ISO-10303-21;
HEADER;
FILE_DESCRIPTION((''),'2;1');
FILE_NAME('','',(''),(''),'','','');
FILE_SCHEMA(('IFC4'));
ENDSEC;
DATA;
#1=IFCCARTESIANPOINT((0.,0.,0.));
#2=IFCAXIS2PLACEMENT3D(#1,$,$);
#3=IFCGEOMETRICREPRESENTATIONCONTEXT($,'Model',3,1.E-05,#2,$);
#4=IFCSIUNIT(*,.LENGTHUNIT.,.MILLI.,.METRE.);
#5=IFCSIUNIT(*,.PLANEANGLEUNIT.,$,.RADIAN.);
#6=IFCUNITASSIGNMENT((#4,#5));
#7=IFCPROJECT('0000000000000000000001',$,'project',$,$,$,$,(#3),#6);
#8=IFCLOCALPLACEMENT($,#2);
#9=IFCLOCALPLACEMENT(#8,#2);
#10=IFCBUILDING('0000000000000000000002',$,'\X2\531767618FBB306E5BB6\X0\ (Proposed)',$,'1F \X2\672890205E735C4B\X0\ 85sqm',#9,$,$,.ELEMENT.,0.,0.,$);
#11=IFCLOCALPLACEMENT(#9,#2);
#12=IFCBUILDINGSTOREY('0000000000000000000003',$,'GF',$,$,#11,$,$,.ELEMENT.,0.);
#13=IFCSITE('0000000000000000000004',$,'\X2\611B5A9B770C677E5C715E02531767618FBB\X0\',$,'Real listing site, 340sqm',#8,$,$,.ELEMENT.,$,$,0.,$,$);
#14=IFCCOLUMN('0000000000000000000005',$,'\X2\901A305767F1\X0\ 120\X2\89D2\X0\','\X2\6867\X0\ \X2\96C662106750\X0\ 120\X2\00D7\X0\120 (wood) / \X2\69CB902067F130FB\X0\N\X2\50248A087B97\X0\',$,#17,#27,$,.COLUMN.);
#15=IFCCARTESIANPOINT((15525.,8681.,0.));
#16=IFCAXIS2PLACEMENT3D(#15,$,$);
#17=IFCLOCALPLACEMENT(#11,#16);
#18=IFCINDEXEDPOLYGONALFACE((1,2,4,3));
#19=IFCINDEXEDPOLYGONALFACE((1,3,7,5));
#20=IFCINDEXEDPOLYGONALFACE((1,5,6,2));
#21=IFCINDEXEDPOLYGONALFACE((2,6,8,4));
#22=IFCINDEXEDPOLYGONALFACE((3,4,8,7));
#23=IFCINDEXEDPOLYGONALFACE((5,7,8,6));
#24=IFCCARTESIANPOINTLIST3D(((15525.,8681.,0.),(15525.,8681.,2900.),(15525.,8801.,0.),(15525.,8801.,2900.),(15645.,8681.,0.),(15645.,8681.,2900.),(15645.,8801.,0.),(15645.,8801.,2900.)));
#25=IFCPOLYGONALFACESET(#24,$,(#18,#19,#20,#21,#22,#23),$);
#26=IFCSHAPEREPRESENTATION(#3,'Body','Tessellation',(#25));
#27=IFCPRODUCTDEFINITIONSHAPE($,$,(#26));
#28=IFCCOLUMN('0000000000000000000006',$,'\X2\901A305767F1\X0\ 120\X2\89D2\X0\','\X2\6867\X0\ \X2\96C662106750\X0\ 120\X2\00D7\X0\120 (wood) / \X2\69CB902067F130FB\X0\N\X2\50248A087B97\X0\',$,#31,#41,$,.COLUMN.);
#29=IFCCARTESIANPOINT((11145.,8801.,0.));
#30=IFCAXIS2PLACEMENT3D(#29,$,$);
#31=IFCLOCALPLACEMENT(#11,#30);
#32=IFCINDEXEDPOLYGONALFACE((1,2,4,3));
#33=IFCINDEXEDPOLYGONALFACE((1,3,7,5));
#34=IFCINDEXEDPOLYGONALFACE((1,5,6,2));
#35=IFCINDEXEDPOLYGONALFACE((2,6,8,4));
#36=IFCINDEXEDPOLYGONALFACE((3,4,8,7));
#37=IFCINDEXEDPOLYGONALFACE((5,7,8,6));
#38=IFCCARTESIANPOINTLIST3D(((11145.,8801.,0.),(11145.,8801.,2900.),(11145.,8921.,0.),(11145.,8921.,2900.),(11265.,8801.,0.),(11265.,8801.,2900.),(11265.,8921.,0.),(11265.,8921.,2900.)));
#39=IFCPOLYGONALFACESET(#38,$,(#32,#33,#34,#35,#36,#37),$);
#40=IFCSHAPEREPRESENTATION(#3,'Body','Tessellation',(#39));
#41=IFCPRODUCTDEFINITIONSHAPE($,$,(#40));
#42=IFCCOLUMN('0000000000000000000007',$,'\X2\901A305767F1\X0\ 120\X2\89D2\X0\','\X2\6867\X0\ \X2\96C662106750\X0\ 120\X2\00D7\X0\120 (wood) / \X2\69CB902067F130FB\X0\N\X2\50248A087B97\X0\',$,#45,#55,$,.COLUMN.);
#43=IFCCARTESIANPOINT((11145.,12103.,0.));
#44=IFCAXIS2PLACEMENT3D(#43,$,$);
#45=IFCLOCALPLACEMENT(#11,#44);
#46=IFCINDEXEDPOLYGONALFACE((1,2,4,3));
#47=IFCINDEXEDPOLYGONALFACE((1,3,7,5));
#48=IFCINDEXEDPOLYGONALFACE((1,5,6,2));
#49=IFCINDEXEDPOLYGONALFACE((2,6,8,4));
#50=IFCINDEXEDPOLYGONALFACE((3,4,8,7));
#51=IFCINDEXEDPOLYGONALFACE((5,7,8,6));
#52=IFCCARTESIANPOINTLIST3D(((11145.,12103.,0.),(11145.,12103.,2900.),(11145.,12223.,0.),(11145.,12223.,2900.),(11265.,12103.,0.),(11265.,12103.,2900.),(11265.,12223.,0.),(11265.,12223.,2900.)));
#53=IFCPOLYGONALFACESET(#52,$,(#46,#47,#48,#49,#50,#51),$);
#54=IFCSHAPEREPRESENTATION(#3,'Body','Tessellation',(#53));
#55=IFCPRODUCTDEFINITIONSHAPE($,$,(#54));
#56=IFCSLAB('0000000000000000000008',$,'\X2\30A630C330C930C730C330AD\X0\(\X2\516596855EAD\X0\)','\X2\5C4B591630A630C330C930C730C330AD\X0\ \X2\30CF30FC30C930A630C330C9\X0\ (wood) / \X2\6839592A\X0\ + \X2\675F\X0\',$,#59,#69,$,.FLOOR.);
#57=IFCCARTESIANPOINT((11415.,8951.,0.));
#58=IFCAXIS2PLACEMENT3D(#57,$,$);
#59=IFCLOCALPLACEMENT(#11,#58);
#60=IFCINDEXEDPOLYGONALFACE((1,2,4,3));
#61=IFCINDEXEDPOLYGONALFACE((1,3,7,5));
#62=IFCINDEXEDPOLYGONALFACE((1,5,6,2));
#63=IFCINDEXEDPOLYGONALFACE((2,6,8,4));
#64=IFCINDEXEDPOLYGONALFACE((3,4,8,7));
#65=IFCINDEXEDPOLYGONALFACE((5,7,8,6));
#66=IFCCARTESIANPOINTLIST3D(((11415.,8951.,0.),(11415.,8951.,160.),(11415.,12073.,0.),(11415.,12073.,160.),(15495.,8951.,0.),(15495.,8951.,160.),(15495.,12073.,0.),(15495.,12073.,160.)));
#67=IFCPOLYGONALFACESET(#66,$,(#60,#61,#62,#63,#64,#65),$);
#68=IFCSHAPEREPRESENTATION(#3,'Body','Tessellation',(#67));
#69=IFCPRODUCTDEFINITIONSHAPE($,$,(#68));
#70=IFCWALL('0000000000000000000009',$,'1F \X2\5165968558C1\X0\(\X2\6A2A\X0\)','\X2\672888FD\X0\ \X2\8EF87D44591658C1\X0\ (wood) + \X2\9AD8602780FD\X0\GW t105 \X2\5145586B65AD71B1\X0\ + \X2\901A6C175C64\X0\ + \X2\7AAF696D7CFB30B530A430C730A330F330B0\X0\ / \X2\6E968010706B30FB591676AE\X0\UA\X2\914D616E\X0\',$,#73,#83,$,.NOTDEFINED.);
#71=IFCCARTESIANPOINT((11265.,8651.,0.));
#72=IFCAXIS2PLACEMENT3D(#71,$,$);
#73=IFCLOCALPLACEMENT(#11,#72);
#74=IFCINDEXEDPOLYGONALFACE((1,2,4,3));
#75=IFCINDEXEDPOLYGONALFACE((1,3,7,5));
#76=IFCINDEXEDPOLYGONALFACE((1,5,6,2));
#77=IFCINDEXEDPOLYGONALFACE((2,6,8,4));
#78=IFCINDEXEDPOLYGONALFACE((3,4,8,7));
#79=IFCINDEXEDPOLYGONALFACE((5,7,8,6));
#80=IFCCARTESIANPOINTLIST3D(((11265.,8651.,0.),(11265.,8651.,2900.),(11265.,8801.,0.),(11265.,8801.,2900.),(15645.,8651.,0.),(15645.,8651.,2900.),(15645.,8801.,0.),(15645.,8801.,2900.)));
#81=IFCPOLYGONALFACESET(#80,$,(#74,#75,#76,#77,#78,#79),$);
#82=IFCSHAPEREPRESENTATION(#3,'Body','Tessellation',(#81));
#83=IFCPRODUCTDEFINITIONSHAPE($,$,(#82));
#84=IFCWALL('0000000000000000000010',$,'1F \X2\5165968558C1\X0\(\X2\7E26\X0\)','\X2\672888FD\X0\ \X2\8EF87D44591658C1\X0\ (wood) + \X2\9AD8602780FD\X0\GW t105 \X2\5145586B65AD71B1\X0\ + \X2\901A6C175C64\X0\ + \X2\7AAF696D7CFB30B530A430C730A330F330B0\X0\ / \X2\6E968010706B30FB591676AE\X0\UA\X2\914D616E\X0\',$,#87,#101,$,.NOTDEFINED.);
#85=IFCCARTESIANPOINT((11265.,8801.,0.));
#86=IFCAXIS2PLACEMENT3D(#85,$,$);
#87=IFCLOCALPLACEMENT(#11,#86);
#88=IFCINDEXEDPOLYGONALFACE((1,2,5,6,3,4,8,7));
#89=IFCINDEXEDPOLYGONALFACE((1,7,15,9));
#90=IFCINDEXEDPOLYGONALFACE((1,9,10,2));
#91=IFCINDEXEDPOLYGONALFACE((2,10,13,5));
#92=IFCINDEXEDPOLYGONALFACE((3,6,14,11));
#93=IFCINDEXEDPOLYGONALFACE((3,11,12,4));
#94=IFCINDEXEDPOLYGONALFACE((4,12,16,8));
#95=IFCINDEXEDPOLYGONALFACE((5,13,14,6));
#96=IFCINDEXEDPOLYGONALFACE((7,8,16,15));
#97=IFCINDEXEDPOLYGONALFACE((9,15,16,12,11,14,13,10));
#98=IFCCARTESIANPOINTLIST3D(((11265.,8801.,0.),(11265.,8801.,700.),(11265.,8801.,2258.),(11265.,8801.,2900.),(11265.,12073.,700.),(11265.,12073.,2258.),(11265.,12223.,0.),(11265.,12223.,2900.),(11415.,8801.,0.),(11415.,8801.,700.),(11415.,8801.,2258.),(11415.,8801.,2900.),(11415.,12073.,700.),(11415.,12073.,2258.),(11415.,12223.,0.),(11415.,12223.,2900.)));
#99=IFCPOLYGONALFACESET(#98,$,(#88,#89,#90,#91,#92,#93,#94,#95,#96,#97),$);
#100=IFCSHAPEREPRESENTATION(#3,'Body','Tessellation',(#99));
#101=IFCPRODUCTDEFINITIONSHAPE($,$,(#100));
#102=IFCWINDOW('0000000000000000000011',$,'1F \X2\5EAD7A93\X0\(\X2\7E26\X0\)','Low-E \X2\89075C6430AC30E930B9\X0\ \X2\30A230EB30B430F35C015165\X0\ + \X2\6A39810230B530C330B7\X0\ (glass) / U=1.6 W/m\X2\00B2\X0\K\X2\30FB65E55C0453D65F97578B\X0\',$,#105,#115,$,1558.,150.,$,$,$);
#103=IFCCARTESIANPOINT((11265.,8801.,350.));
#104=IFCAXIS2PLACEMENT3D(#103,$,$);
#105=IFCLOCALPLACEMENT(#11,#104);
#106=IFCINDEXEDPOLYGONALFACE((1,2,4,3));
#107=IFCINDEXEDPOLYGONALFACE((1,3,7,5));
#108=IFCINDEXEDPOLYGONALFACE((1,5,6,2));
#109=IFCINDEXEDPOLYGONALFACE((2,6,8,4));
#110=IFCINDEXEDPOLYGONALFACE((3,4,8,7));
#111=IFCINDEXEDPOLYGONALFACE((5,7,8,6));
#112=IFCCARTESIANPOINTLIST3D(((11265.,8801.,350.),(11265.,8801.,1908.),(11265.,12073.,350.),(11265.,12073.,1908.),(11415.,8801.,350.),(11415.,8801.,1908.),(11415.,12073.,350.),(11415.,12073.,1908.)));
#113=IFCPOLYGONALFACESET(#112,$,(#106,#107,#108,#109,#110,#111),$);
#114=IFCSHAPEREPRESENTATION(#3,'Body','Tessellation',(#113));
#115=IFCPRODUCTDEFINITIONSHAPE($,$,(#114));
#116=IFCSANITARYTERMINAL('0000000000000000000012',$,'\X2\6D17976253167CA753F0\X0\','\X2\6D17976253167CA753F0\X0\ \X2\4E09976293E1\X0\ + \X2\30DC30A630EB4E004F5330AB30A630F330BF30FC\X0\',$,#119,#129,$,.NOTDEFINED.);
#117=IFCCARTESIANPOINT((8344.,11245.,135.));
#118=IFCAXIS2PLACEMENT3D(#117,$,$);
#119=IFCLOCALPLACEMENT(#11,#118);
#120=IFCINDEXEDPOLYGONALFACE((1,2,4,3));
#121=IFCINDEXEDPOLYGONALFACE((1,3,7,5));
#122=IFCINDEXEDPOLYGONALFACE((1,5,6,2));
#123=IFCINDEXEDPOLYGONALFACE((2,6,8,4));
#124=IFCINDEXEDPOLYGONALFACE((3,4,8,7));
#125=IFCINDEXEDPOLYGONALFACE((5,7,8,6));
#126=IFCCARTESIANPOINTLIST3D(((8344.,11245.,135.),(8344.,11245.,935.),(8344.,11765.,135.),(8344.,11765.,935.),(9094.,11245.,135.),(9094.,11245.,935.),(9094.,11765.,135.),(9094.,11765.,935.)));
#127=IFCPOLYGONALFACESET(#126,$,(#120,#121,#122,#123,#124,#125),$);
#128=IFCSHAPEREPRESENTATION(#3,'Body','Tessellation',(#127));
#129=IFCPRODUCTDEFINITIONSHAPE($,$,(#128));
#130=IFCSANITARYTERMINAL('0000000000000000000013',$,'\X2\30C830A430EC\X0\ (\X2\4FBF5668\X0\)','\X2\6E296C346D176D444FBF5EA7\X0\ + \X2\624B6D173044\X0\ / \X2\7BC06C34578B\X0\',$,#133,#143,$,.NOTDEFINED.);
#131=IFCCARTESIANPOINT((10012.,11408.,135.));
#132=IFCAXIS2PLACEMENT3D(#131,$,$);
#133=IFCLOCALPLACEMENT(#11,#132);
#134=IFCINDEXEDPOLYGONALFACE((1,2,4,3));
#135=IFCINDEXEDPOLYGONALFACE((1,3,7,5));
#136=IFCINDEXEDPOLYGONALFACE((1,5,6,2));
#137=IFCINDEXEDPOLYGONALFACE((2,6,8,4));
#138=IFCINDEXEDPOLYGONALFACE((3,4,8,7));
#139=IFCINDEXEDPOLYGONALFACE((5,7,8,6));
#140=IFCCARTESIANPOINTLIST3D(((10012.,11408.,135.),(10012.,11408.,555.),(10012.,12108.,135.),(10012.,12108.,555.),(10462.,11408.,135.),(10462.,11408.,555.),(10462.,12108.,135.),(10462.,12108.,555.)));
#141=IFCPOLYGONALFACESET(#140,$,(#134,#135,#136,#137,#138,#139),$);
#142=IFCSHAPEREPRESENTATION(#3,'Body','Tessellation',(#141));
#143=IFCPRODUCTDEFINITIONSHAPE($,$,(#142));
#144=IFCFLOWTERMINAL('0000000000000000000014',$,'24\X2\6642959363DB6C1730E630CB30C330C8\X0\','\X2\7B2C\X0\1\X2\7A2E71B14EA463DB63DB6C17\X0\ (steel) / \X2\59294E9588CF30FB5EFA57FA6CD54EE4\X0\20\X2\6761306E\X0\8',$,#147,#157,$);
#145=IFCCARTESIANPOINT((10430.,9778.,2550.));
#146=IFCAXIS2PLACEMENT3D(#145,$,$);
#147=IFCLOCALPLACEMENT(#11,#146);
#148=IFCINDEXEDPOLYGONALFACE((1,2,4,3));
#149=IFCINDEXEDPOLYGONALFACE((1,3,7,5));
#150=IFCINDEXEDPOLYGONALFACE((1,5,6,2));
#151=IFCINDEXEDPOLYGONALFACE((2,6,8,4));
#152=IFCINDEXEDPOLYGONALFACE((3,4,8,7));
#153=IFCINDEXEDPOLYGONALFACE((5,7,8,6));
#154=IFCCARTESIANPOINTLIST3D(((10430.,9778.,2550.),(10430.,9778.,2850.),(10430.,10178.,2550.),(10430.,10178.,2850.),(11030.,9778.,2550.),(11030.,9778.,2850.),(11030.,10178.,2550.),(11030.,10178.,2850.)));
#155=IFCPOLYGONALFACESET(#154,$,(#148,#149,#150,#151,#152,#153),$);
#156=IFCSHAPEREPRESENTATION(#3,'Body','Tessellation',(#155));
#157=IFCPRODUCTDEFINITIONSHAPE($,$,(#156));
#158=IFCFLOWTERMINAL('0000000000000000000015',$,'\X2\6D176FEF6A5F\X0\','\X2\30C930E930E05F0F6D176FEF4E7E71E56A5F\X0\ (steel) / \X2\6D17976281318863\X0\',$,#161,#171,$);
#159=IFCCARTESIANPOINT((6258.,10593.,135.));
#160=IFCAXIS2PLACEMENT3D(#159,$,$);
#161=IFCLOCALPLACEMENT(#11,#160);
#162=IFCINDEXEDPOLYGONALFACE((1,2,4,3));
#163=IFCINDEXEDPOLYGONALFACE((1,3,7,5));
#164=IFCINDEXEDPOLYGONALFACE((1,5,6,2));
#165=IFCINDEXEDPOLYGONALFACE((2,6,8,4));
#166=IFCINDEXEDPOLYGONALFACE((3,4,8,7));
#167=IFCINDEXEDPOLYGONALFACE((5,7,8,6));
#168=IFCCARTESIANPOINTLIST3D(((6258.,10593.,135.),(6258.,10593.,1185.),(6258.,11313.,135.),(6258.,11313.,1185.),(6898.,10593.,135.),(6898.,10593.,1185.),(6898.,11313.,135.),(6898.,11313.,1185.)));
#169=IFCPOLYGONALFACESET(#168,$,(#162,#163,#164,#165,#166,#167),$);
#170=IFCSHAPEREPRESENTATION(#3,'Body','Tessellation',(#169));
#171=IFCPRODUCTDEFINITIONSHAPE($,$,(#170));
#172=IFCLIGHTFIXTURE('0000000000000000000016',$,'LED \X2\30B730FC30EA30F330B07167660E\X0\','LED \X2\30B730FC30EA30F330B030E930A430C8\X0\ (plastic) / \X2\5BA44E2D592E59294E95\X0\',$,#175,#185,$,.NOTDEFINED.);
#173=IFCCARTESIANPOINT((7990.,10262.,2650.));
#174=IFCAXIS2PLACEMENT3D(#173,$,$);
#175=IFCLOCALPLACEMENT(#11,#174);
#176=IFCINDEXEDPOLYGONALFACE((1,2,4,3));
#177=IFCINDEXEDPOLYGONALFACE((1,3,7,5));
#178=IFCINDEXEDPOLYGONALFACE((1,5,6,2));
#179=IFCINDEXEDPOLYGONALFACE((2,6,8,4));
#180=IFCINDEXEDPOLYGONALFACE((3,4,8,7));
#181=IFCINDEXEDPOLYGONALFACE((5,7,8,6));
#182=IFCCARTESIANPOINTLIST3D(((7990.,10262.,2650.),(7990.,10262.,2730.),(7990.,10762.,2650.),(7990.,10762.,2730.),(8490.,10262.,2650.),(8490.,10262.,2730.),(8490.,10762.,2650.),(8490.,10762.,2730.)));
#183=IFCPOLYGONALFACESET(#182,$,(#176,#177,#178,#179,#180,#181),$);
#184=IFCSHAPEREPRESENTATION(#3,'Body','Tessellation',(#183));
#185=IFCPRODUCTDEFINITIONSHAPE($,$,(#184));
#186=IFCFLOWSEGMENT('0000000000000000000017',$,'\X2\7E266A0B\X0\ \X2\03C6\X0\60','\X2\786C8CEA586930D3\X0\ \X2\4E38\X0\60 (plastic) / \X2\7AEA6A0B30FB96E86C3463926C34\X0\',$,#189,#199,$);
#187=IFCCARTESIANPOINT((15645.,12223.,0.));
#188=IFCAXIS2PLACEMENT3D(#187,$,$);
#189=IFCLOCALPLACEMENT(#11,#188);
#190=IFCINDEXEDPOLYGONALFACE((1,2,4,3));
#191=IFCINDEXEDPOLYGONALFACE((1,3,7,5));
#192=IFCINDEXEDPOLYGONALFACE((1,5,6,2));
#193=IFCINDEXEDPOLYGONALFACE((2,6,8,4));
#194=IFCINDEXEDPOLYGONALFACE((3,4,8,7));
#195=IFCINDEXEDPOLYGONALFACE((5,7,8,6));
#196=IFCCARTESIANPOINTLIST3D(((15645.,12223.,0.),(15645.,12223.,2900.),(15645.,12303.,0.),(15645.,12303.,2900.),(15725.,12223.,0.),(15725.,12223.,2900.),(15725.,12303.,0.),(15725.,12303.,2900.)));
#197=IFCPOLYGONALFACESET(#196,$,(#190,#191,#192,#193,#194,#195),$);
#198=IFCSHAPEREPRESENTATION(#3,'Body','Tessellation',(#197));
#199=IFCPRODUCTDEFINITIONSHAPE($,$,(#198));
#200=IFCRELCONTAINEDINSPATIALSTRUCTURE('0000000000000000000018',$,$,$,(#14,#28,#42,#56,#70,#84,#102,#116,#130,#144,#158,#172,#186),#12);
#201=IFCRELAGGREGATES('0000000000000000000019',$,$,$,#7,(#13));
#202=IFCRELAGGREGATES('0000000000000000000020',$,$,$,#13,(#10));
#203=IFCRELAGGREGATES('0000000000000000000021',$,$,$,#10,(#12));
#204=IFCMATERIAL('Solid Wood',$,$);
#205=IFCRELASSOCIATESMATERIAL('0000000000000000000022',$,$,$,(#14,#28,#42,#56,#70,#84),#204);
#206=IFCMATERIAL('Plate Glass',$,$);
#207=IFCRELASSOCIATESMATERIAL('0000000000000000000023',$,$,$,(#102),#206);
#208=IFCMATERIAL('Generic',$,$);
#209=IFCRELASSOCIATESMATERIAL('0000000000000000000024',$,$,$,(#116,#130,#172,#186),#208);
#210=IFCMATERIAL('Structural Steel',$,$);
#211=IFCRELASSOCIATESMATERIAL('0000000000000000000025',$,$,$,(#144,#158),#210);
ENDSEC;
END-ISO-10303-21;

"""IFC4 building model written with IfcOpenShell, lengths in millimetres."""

from ifc_helpers import new_model, si_unit, frame, frame_2d, origin, place, context, project, spatial, rectangle, extrude, material, element, fill, save


model = new_model("IFC4")

# Units and contexts
model_context = context("Model", 3, precision=1e-05, world=origin())
ifc_project = project(units=[si_unit("LENGTHUNIT", "METRE", prefix="MILLI"), si_unit("PLANEANGLEUNIT", "RADIAN")], contexts=[model_context])

# Site, building, storey
site_placement = place(None, origin())
site = spatial("IfcSite", under=ifc_project, at=site_placement, Name="愛媛県松山市北条辻", ObjectType="Real listing site, 340sqm", CompositionType="ELEMENT", RefElevation=0.0)
building_placement = place(site_placement, origin())
building = spatial("IfcBuilding", under=site, at=building_placement, Name="北条辻の家 (Proposed)", ObjectType="1F 木造平屋 85sqm", CompositionType="ELEMENT", ElevationOfRefHeight=0.0, ElevationOfTerrain=0.0)
storey_placement = place(building_placement, origin())
storey = spatial("IfcBuildingStorey", under=building, at=storey_placement, Name="GF", CompositionType="ELEMENT", Elevation=0.0)

# Columns
ifc_material_1 = material(Name="Solid Wood")
column_1_placement = place(storey_placement, frame((15525.0, 8681.0, 0.0)))
element("IfcColumn", 1, at=column_1_placement, inside=storey, material=ifc_material_1, Name="通し柱 120角", Description="桧 集成材 120×120 (wood) / 構造柱・N値計算", PredefinedType="COLUMN", context=model_context, shape_type="SweptSolid", body=[
    extrude(rectangle(XDim=120.0, YDim=120.0, at=frame_2d((60.0, 60.0))), frame((15525.0, 8681.0, 0.0)), (0.0, 0.0, 1.0), 2900.0),
])
column_2_placement = place(storey_placement, frame((11145.0, 8801.0, 0.0)))
element("IfcColumn", 2, at=column_2_placement, inside=storey, material=ifc_material_1, Name="通し柱 120角", Description="桧 集成材 120×120 (wood) / 構造柱・N値計算", PredefinedType="COLUMN", context=model_context, shape_type="SweptSolid", body=[
    extrude(rectangle(XDim=120.0, YDim=120.0, at=frame_2d((60.0, 60.0))), frame((11145.0, 8801.0, 0.0)), (0.0, 0.0, 1.0), 2900.0),
])
column_3_placement = place(storey_placement, frame((11145.0, 12103.0, 0.0)))
element("IfcColumn", 3, at=column_3_placement, inside=storey, material=ifc_material_1, Name="通し柱 120角", Description="桧 集成材 120×120 (wood) / 構造柱・N値計算", PredefinedType="COLUMN", context=model_context, shape_type="SweptSolid", body=[
    extrude(rectangle(XDim=120.0, YDim=120.0, at=frame_2d((60.0, 60.0))), frame((11145.0, 12103.0, 0.0)), (0.0, 0.0, 1.0), 2900.0),
])

# Slab
slab_placement = place(storey_placement, frame((11415.0, 8951.0, 0.0)))
element("IfcSlab", 4, at=slab_placement, inside=storey, material=ifc_material_1, Name="ウッドデッキ(入隅庭)", Description="屋外ウッドデッキ ハードウッド (wood) / 根太 + 束", PredefinedType="FLOOR", context=model_context, shape_type="SweptSolid", body=[
    extrude(rectangle(XDim=4080.0, YDim=3122.0, at=frame_2d((2040.0, 1561.0))), frame((11415.0, 8951.0, 0.0)), (0.0, 0.0, 1.0), 160.0),
])

# Wall
wall_1_placement = place(storey_placement, frame((11265.0, 8651.0, 0.0)))
element("IfcWall", 5, at=wall_1_placement, inside=storey, material=ifc_material_1, Name="1F 入隅壁(横)", Description="木製 軸組外壁 (wood) + 高性能GW t105 充填断熱 + 通気層 + 窯業系サイディング / 準耐火・外皮UA配慮", PredefinedType="NOTDEFINED", context=model_context, shape_type="SweptSolid", body=[
    extrude(rectangle(XDim=4380.0, YDim=150.0, at=frame_2d((2190.0, 75.0))), frame((11265.0, 8651.0, 0.0)), (0.0, 0.0, 1.0), 2900.0),
])

# Wall, opening, window
wall_2_placement = place(storey_placement, frame((11265.0, 8801.0, 0.0)))
wall_2 = element("IfcWall", 6, at=wall_2_placement, inside=storey, material=ifc_material_1, Name="1F 入隅壁(縦)", Description="木製 軸組外壁 (wood) + 高性能GW t105 充填断熱 + 通気層 + 窯業系サイディング / 準耐火・外皮UA配慮", PredefinedType="NOTDEFINED", context=model_context, shape_type="SweptSolid", body=[
    extrude(rectangle(XDim=150.0, YDim=3422.0, at=frame_2d((75.0, 1711.0))), frame((11265.0, 8801.0, 0.0)), (0.0, 0.0, 1.0), 2900.0),
])
opening_placement = place(storey_placement, frame((11265.0, 8801.0, 350.0)))
opening = element("IfcOpeningElement", 7, at=opening_placement, cuts=wall_2, PredefinedType="NOTDEFINED", context=model_context, shape_type="SweptSolid", body=[
    extrude(rectangle(XDim=150.0, YDim=3272.0, at=frame_2d((75.0, 1636.0))), frame((11265.0, 8801.0, 350.0)), (0.0, 0.0, 1.0), 1558.0),
])
ifc_material_2 = material(Name="Plate Glass")
window_placement = place(storey_placement, frame((11265.0, 8801.0, 350.0)))
window = element("IfcWindow", 8, at=window_placement, inside=storey, material=ifc_material_2, Name="1F 庭窓(縦)", Description="Low-E 複層ガラス アルゴン封入 + 樹脂サッシ (glass) / U=1.6 W/m²K・日射取得型", OverallHeight=1558.0, OverallWidth=150.0, context=model_context, shape_type="SweptSolid", body=[
    extrude(rectangle(XDim=150.0, YDim=3272.0, at=frame_2d((75.0, 1636.0))), frame((11265.0, 8801.0, 350.0)), (0.0, 0.0, 1.0), 1558.0),
])
fill(opening, window)

# Sanitary terminals
ifc_material_3 = material(Name="Generic")
sanitary_terminal_1_placement = place(storey_placement, frame((8344.0, 11245.0, 135.0)))
element("IfcSanitaryTerminal", 9, at=sanitary_terminal_1_placement, inside=storey, material=ifc_material_3, Name="洗面化粧台", Description="洗面化粧台 三面鏡 + ボウル一体カウンター", PredefinedType="NOTDEFINED", context=model_context, shape_type="SweptSolid", body=[
    extrude(rectangle(XDim=750.0, YDim=520.0, at=frame_2d((375.0, 260.0))), frame((8344.0, 11245.0, 135.0)), (0.0, 0.0, 1.0), 800.0),
])
sanitary_terminal_2_placement = place(storey_placement, frame((10012.0, 11408.0, 135.0)))
element("IfcSanitaryTerminal", 10, at=sanitary_terminal_2_placement, inside=storey, material=ifc_material_3, Name="トイレ (便器)", Description="温水洗浄便座 + 手洗い / 節水型", PredefinedType="NOTDEFINED", context=model_context, shape_type="SweptSolid", body=[
    extrude(rectangle(XDim=450.0, YDim=700.0, at=frame_2d((225.0, 350.0))), frame((10012.0, 11408.0, 135.0)), (0.0, 0.0, 1.0), 420.0),
])

# Flow terminals
ifc_material_4 = material(Name="Structural Steel")
flow_terminal_1_placement = place(storey_placement, frame((10430.0, 9778.0, 2550.0)))
element("IfcFlowTerminal", 11, at=flow_terminal_1_placement, inside=storey, material=ifc_material_4, Name="24時間換気ユニット", Description="第1種熱交換換気 (steel) / 天井裏・建基法令20条の8", context=model_context, shape_type="SweptSolid", body=[
    extrude(rectangle(XDim=600.0, YDim=400.0, at=frame_2d((300.0, 200.0))), frame((10430.0, 9778.0, 2550.0)), (0.0, 0.0, 1.0), 300.0),
])
flow_terminal_2_placement = place(storey_placement, frame((6258.0, 10593.0, 135.0)))
element("IfcFlowTerminal", 12, at=flow_terminal_2_placement, inside=storey, material=ifc_material_4, Name="洗濯機", Description="ドラム式洗濯乾燥機 (steel) / 洗面脱衣", context=model_context, shape_type="SweptSolid", body=[
    extrude(rectangle(XDim=640.0, YDim=720.0, at=frame_2d((320.0, 360.0))), frame((6258.0, 10593.0, 135.0)), (0.0, 0.0, 1.0), 1050.0),
])

# Light fixture
light_fixture_placement = place(storey_placement, frame((7990.0, 10262.0, 2650.0)))
element("IfcLightFixture", 13, at=light_fixture_placement, inside=storey, material=ifc_material_3, Name="LED シーリング照明", Description="LED シーリングライト (plastic) / 室中央天井", PredefinedType="NOTDEFINED", context=model_context, shape_type="SweptSolid", body=[
    extrude(rectangle(XDim=500.0, YDim=500.0, at=frame_2d((250.0, 250.0))), frame((7990.0, 10262.0, 2650.0)), (0.0, 0.0, 1.0), 80.0),
])

# Flow segment
flow_segment_placement = place(storey_placement, frame((15645.0, 12223.0, 0.0)))
element("IfcFlowSegment", 14, at=flow_segment_placement, inside=storey, material=ifc_material_3, Name="縦樋 φ60", Description="硬質塩ビ 丸60 (plastic) / 竪樋・雨水排水", context=model_context, shape_type="SweptSolid", body=[
    extrude(rectangle(XDim=80.0, YDim=80.0, at=frame_2d((40.0, 40.0))), frame((15645.0, 12223.0, 0.0)), (0.0, 0.0, 1.0), 2900.0),
])

save(model, "model.ifc")
